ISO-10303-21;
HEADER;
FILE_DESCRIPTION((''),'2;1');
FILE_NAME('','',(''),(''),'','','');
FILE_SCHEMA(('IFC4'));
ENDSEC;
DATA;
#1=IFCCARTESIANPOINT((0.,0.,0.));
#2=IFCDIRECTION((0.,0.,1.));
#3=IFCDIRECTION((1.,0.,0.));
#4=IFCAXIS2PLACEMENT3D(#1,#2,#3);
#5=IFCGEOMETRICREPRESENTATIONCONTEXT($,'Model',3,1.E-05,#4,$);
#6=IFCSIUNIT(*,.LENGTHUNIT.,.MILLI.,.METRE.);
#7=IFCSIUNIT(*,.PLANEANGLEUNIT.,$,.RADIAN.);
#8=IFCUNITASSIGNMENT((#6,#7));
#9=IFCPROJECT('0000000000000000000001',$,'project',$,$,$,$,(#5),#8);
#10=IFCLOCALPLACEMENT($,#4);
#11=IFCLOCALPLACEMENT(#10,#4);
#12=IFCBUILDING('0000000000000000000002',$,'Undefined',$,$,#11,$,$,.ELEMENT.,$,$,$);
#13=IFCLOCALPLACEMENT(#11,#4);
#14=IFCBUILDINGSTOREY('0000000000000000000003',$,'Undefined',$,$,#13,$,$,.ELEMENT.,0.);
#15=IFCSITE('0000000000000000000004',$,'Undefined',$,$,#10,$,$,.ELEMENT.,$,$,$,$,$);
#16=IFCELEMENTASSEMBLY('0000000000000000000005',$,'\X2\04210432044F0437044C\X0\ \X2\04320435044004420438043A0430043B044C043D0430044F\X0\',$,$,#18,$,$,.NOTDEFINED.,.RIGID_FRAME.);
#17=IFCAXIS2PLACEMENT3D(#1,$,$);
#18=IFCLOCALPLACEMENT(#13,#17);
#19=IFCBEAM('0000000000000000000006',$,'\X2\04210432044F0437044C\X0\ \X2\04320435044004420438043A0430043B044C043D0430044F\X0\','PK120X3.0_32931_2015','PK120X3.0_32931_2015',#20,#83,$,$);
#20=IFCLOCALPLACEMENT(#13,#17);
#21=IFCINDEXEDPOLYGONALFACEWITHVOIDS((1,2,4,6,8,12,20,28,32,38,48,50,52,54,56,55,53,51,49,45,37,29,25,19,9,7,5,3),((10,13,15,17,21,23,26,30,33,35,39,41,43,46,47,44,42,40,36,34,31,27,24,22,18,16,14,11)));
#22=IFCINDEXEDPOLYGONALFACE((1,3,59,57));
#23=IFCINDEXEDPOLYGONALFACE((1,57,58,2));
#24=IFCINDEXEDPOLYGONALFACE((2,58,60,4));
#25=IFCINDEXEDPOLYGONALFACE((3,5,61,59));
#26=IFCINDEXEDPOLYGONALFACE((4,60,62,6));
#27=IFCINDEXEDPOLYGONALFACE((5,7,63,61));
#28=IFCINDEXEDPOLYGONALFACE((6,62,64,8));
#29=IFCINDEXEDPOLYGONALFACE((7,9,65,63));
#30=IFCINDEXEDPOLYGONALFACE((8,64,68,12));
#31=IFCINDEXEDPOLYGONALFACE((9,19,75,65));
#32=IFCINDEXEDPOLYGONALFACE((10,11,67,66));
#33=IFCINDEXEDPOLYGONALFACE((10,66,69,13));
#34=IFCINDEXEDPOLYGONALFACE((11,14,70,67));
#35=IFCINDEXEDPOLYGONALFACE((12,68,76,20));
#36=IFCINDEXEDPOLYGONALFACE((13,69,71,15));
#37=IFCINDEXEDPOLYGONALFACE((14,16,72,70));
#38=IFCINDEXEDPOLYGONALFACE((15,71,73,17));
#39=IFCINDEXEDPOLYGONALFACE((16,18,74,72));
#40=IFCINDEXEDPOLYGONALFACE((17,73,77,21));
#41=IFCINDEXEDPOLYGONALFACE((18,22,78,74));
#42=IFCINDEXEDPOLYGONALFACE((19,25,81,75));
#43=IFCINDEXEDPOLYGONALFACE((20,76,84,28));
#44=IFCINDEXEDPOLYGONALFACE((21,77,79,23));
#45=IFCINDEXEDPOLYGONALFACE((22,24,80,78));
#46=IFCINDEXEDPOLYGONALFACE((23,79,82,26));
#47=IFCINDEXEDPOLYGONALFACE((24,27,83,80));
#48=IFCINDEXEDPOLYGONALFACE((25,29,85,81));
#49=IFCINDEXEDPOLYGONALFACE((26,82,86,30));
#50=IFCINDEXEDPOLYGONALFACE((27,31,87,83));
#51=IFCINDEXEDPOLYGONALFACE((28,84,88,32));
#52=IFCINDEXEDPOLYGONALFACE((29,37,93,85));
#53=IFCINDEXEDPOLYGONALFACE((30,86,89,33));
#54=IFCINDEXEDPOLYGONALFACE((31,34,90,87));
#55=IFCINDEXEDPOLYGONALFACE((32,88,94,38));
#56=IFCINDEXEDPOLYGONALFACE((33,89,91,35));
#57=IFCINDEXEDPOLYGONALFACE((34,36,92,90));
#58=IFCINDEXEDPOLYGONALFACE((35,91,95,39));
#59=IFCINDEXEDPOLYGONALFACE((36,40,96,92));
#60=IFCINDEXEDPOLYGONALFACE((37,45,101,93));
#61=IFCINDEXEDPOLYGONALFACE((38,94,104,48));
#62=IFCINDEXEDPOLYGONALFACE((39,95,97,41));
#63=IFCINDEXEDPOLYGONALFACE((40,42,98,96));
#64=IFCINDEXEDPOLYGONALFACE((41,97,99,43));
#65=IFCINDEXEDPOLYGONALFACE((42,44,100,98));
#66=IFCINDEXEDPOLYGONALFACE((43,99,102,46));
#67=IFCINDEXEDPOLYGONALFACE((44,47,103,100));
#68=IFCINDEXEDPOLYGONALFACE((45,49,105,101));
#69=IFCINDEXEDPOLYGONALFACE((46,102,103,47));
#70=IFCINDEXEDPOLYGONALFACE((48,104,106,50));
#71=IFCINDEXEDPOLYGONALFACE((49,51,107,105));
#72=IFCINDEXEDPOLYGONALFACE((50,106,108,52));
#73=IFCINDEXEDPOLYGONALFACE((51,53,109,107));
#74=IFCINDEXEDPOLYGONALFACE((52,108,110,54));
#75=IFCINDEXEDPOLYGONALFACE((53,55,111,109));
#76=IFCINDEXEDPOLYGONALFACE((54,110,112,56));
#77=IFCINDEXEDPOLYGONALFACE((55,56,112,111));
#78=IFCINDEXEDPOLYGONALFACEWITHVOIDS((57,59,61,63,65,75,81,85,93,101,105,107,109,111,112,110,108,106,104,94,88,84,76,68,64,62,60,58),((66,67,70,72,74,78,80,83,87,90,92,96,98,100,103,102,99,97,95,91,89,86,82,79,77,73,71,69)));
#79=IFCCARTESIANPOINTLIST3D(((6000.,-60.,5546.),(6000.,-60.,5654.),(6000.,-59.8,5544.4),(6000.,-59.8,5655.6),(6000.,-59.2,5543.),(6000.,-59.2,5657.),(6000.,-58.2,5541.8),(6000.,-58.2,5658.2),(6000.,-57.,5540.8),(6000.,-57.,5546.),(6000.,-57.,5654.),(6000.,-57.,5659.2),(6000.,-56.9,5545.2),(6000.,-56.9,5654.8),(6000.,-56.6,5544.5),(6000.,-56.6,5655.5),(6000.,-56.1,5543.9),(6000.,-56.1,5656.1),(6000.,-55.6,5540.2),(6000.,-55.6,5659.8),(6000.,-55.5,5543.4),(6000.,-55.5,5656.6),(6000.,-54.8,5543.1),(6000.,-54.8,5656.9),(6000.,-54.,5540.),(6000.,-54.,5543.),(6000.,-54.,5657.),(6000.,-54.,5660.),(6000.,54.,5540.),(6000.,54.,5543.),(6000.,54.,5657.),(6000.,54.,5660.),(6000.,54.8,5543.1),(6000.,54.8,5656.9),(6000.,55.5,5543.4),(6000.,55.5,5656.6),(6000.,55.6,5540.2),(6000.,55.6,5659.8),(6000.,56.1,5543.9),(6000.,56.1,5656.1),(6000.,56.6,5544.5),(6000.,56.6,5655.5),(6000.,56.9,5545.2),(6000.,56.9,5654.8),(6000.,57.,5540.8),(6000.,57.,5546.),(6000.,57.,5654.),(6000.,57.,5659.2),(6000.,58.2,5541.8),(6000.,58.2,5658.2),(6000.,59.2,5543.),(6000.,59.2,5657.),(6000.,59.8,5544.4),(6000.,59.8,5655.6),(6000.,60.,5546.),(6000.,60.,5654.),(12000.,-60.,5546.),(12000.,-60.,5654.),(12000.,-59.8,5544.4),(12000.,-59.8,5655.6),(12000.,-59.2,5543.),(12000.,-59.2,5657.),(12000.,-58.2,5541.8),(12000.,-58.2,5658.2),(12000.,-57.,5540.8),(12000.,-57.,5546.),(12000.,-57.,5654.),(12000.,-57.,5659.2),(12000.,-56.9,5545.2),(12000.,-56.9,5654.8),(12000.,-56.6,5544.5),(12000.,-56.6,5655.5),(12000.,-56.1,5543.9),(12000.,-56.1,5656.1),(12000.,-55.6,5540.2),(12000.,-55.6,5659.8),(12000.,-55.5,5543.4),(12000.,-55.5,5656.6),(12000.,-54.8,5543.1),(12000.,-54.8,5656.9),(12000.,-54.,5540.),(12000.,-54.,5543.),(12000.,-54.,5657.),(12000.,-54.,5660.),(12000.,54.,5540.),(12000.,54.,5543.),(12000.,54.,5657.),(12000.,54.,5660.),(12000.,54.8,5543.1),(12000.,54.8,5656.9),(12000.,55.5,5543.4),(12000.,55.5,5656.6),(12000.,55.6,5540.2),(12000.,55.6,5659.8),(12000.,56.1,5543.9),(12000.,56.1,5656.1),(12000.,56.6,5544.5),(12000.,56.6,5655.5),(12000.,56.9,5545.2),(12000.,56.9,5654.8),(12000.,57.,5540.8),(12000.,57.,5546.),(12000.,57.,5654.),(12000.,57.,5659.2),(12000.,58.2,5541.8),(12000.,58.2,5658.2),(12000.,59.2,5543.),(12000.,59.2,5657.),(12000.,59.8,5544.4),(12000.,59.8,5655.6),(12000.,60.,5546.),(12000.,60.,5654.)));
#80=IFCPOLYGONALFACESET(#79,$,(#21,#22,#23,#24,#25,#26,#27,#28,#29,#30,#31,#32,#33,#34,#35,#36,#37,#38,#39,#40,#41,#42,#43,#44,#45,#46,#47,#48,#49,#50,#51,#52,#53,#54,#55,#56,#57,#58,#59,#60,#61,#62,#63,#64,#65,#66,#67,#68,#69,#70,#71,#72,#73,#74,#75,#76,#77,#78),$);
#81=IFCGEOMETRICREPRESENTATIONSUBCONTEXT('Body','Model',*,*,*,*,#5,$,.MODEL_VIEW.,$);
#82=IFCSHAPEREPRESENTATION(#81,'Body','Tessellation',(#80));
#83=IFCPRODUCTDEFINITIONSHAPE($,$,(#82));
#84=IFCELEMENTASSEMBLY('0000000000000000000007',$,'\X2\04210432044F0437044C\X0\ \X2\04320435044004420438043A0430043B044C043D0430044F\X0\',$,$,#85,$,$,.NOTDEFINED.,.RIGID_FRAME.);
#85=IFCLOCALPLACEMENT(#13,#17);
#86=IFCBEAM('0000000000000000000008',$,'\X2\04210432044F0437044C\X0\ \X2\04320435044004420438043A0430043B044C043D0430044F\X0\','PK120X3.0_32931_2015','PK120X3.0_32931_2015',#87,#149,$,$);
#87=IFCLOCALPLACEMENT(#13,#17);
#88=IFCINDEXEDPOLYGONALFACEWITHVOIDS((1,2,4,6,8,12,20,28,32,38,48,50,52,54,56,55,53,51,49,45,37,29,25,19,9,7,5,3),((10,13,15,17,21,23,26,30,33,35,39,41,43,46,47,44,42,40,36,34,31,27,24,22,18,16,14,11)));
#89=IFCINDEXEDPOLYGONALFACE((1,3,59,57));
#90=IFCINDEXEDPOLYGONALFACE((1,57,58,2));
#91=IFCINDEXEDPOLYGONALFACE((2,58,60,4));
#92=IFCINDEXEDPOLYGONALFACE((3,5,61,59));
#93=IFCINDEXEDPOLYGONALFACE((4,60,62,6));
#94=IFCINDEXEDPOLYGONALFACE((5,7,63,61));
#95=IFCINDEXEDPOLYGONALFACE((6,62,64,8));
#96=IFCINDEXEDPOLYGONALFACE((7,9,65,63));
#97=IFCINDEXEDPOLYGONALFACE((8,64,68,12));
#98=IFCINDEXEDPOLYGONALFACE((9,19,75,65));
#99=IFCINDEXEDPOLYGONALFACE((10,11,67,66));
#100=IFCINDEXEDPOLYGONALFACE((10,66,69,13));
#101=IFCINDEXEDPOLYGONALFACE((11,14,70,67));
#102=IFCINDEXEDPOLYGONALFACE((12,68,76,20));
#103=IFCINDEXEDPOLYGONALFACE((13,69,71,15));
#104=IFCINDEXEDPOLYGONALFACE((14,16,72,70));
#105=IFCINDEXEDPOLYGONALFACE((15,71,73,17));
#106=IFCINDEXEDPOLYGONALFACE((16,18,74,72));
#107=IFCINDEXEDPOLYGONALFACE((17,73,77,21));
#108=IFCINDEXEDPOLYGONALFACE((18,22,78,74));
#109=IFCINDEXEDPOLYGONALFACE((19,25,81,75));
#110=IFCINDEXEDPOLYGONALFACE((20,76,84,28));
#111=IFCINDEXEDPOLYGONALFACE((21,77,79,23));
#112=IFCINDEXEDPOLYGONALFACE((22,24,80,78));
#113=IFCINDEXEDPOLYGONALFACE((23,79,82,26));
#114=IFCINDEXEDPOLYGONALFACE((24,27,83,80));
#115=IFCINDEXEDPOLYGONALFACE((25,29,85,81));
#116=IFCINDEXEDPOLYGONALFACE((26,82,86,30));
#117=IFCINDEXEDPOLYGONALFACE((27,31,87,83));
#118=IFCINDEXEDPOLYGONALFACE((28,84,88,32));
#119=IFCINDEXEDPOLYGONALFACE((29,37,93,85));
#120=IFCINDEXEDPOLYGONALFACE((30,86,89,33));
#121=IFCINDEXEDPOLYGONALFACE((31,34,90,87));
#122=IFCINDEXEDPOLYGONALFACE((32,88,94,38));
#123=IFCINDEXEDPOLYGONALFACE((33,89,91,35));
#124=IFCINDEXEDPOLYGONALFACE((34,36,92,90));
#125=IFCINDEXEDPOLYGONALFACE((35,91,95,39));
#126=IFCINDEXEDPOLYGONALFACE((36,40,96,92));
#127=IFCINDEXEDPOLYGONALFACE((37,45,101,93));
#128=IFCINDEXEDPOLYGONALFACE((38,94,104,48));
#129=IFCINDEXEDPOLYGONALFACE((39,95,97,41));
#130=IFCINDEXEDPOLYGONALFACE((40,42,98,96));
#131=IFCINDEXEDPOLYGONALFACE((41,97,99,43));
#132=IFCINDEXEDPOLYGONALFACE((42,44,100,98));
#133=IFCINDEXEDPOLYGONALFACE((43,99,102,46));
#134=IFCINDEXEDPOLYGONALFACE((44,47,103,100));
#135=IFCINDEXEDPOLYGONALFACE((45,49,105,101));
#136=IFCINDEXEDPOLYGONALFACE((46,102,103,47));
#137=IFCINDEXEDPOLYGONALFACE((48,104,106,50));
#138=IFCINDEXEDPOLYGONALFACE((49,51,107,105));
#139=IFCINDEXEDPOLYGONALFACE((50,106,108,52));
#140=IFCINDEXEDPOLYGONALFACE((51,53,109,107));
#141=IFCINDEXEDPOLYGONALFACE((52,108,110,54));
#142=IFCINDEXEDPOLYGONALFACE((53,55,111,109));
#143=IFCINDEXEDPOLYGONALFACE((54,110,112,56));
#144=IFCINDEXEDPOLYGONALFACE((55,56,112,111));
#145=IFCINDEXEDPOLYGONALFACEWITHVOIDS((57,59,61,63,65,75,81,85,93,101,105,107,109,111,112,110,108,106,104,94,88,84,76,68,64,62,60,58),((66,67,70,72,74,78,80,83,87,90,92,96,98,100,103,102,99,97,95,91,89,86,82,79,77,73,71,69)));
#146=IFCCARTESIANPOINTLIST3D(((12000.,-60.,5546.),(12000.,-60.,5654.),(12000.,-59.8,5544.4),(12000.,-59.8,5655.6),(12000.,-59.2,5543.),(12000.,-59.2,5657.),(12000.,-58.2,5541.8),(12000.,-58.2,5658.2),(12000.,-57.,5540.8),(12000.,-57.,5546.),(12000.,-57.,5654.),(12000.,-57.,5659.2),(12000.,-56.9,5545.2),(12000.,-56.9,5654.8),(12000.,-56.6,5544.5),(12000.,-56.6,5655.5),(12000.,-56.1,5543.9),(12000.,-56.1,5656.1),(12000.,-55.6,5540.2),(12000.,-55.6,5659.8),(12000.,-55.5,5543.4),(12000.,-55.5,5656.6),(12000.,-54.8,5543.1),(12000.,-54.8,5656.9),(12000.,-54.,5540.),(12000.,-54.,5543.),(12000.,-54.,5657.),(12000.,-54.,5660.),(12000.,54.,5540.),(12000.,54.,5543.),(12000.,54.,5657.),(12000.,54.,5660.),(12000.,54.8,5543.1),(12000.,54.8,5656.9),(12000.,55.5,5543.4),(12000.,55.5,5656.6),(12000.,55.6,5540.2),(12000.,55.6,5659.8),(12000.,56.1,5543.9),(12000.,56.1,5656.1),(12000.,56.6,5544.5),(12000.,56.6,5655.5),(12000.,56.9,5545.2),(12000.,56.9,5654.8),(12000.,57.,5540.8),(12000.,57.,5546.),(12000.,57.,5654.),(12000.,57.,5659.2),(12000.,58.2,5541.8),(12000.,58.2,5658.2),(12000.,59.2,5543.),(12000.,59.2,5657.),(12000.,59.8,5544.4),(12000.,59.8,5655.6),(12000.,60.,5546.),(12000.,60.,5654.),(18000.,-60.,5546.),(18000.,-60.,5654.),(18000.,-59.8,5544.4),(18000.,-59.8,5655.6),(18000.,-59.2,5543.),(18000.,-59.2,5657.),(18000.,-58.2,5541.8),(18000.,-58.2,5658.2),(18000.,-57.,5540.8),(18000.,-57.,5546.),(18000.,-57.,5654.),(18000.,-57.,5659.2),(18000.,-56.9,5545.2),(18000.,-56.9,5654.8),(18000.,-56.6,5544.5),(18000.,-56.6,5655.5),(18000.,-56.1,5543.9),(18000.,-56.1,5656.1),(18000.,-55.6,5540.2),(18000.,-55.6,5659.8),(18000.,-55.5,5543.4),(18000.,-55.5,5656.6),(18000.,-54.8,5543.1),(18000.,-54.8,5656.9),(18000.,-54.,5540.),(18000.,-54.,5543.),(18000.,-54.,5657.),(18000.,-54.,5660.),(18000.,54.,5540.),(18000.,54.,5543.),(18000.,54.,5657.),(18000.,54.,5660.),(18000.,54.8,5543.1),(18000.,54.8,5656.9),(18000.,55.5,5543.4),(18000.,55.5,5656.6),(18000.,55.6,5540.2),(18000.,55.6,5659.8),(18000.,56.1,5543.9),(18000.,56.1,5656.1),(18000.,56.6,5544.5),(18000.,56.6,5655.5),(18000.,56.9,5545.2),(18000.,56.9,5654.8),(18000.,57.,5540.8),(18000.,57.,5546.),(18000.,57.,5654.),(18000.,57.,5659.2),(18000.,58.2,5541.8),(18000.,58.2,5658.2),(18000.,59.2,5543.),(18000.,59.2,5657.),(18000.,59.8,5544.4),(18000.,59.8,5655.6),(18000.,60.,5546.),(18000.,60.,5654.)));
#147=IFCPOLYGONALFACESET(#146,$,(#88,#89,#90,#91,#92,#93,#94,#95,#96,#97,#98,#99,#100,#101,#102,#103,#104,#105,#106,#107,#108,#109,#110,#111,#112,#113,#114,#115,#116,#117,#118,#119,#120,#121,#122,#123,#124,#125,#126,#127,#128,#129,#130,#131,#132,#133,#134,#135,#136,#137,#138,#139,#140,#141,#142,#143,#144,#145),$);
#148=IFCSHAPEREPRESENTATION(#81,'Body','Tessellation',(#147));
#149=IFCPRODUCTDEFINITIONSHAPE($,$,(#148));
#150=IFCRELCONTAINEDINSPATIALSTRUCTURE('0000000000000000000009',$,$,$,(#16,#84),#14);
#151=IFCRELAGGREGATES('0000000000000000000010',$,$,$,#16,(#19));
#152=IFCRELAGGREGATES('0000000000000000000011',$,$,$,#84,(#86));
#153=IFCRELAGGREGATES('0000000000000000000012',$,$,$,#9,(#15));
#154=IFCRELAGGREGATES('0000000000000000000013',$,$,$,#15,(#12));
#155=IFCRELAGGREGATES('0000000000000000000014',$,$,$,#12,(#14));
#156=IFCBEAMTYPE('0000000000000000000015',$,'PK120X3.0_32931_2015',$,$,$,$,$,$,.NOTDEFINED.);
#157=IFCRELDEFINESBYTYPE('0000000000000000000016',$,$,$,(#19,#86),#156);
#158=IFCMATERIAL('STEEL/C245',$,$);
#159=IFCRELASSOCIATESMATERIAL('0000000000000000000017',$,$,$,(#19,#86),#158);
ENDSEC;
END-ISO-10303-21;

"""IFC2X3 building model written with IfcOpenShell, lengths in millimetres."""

from ifc_helpers import new_model, si_unit, frame, origin_with_axes, origin_2d_with_axis, place, context, subcontext, project, spatial, hollow_rectangle, extrude, material, type_object, element, aggregate, save


model = new_model("IFC2X3")

# Units and contexts
model_context = context("Model", 3, precision=1e-05, world=origin_with_axes())
body_context = subcontext(model_context, "Body", "Model", "MODEL_VIEW")
ifc_project = project(units=[si_unit("LENGTHUNIT", "METRE", prefix="MILLI"), si_unit("PLANEANGLEUNIT", "RADIAN")], contexts=[model_context])

# Site, building, storey
site_placement = place(None, origin_with_axes())
site = spatial("IfcSite", under=ifc_project, at=site_placement, Name="Undefined", CompositionType="ELEMENT")
building_placement = place(site_placement, origin_with_axes())
building = spatial("IfcBuilding", under=site, at=building_placement, Name="Undefined", CompositionType="ELEMENT")
storey_placement = place(building_placement, origin_with_axes())
storey = spatial("IfcBuildingStorey", under=building, at=storey_placement, Name="Undefined", CompositionType="ELEMENT", Elevation=0.0)

# Shared definitions
ifc_material_1 = material(Name="STEEL/C245")

# Element assemblies, beams
beam_type_1 = type_object("IfcBeamType", Name="PK120X3.0_32931_2015", PredefinedType="NOTDEFINED")
assembly_1_placement = place(storey_placement, origin_with_axes())
assembly_1 = element("IfcElementAssembly", 1, at=assembly_1_placement, inside=storey, Name="Связь вертикальная", AssemblyPlace="NOTDEFINED", PredefinedType="RIGID_FRAME")
beam_1_placement = place(assembly_1_placement, frame((6000.0, 0.0, 5600.0), z_axis=(0.0, 0.0, 1.0), x_axis=(1.0, 0.0, 0.0)))
beam_1 = element("IfcBeam", 2, at=beam_1_placement, type_object=beam_type_1, material=ifc_material_1, Name="Связь вертикальная", Description="PK120X3.0_32931_2015", ObjectType="PK120X3.0_32931_2015", context=body_context, shape_type="SweptSolid", body=[
    extrude(hollow_rectangle(XDim=120.0, YDim=120.0, WallThickness=3.0, InnerFilletRadius=3.0, OuterFilletRadius=6.0, at=origin_2d_with_axis()), frame((6000.0, 0.0, 0.0), z_axis=(-1.0, 0.0, 0.0), x_axis=(0.0, -1.0, 0.0)), (0.0, 0.0, 1.0), 6000.0),
])
aggregate(assembly_1, [beam_1])
assembly_2_placement = place(storey_placement, origin_with_axes())
assembly_2 = element("IfcElementAssembly", 3, at=assembly_2_placement, inside=storey, Name="Связь вертикальная", AssemblyPlace="NOTDEFINED", PredefinedType="RIGID_FRAME")
beam_2_placement = place(assembly_2_placement, frame((12000.0, 0.0, 5600.0), z_axis=(0.0, 0.0, 1.0), x_axis=(1.0, 0.0, 0.0)))
beam_2 = element("IfcBeam", 4, at=beam_2_placement, type_object=beam_type_1, material=ifc_material_1, Name="Связь вертикальная", Description="PK120X3.0_32931_2015", ObjectType="PK120X3.0_32931_2015", context=body_context, shape_type="SweptSolid", body=[
    extrude(hollow_rectangle(XDim=120.0, YDim=120.0, WallThickness=3.0, InnerFilletRadius=3.0, OuterFilletRadius=6.0, at=origin_2d_with_axis()), frame((6000.0, 0.0, 0.0), z_axis=(-1.0, 0.0, 0.0), x_axis=(0.0, -1.0, 0.0)), (0.0, 0.0, 1.0), 6000.0),
])
aggregate(assembly_2, [beam_2])

save(model, "model.ifc")
